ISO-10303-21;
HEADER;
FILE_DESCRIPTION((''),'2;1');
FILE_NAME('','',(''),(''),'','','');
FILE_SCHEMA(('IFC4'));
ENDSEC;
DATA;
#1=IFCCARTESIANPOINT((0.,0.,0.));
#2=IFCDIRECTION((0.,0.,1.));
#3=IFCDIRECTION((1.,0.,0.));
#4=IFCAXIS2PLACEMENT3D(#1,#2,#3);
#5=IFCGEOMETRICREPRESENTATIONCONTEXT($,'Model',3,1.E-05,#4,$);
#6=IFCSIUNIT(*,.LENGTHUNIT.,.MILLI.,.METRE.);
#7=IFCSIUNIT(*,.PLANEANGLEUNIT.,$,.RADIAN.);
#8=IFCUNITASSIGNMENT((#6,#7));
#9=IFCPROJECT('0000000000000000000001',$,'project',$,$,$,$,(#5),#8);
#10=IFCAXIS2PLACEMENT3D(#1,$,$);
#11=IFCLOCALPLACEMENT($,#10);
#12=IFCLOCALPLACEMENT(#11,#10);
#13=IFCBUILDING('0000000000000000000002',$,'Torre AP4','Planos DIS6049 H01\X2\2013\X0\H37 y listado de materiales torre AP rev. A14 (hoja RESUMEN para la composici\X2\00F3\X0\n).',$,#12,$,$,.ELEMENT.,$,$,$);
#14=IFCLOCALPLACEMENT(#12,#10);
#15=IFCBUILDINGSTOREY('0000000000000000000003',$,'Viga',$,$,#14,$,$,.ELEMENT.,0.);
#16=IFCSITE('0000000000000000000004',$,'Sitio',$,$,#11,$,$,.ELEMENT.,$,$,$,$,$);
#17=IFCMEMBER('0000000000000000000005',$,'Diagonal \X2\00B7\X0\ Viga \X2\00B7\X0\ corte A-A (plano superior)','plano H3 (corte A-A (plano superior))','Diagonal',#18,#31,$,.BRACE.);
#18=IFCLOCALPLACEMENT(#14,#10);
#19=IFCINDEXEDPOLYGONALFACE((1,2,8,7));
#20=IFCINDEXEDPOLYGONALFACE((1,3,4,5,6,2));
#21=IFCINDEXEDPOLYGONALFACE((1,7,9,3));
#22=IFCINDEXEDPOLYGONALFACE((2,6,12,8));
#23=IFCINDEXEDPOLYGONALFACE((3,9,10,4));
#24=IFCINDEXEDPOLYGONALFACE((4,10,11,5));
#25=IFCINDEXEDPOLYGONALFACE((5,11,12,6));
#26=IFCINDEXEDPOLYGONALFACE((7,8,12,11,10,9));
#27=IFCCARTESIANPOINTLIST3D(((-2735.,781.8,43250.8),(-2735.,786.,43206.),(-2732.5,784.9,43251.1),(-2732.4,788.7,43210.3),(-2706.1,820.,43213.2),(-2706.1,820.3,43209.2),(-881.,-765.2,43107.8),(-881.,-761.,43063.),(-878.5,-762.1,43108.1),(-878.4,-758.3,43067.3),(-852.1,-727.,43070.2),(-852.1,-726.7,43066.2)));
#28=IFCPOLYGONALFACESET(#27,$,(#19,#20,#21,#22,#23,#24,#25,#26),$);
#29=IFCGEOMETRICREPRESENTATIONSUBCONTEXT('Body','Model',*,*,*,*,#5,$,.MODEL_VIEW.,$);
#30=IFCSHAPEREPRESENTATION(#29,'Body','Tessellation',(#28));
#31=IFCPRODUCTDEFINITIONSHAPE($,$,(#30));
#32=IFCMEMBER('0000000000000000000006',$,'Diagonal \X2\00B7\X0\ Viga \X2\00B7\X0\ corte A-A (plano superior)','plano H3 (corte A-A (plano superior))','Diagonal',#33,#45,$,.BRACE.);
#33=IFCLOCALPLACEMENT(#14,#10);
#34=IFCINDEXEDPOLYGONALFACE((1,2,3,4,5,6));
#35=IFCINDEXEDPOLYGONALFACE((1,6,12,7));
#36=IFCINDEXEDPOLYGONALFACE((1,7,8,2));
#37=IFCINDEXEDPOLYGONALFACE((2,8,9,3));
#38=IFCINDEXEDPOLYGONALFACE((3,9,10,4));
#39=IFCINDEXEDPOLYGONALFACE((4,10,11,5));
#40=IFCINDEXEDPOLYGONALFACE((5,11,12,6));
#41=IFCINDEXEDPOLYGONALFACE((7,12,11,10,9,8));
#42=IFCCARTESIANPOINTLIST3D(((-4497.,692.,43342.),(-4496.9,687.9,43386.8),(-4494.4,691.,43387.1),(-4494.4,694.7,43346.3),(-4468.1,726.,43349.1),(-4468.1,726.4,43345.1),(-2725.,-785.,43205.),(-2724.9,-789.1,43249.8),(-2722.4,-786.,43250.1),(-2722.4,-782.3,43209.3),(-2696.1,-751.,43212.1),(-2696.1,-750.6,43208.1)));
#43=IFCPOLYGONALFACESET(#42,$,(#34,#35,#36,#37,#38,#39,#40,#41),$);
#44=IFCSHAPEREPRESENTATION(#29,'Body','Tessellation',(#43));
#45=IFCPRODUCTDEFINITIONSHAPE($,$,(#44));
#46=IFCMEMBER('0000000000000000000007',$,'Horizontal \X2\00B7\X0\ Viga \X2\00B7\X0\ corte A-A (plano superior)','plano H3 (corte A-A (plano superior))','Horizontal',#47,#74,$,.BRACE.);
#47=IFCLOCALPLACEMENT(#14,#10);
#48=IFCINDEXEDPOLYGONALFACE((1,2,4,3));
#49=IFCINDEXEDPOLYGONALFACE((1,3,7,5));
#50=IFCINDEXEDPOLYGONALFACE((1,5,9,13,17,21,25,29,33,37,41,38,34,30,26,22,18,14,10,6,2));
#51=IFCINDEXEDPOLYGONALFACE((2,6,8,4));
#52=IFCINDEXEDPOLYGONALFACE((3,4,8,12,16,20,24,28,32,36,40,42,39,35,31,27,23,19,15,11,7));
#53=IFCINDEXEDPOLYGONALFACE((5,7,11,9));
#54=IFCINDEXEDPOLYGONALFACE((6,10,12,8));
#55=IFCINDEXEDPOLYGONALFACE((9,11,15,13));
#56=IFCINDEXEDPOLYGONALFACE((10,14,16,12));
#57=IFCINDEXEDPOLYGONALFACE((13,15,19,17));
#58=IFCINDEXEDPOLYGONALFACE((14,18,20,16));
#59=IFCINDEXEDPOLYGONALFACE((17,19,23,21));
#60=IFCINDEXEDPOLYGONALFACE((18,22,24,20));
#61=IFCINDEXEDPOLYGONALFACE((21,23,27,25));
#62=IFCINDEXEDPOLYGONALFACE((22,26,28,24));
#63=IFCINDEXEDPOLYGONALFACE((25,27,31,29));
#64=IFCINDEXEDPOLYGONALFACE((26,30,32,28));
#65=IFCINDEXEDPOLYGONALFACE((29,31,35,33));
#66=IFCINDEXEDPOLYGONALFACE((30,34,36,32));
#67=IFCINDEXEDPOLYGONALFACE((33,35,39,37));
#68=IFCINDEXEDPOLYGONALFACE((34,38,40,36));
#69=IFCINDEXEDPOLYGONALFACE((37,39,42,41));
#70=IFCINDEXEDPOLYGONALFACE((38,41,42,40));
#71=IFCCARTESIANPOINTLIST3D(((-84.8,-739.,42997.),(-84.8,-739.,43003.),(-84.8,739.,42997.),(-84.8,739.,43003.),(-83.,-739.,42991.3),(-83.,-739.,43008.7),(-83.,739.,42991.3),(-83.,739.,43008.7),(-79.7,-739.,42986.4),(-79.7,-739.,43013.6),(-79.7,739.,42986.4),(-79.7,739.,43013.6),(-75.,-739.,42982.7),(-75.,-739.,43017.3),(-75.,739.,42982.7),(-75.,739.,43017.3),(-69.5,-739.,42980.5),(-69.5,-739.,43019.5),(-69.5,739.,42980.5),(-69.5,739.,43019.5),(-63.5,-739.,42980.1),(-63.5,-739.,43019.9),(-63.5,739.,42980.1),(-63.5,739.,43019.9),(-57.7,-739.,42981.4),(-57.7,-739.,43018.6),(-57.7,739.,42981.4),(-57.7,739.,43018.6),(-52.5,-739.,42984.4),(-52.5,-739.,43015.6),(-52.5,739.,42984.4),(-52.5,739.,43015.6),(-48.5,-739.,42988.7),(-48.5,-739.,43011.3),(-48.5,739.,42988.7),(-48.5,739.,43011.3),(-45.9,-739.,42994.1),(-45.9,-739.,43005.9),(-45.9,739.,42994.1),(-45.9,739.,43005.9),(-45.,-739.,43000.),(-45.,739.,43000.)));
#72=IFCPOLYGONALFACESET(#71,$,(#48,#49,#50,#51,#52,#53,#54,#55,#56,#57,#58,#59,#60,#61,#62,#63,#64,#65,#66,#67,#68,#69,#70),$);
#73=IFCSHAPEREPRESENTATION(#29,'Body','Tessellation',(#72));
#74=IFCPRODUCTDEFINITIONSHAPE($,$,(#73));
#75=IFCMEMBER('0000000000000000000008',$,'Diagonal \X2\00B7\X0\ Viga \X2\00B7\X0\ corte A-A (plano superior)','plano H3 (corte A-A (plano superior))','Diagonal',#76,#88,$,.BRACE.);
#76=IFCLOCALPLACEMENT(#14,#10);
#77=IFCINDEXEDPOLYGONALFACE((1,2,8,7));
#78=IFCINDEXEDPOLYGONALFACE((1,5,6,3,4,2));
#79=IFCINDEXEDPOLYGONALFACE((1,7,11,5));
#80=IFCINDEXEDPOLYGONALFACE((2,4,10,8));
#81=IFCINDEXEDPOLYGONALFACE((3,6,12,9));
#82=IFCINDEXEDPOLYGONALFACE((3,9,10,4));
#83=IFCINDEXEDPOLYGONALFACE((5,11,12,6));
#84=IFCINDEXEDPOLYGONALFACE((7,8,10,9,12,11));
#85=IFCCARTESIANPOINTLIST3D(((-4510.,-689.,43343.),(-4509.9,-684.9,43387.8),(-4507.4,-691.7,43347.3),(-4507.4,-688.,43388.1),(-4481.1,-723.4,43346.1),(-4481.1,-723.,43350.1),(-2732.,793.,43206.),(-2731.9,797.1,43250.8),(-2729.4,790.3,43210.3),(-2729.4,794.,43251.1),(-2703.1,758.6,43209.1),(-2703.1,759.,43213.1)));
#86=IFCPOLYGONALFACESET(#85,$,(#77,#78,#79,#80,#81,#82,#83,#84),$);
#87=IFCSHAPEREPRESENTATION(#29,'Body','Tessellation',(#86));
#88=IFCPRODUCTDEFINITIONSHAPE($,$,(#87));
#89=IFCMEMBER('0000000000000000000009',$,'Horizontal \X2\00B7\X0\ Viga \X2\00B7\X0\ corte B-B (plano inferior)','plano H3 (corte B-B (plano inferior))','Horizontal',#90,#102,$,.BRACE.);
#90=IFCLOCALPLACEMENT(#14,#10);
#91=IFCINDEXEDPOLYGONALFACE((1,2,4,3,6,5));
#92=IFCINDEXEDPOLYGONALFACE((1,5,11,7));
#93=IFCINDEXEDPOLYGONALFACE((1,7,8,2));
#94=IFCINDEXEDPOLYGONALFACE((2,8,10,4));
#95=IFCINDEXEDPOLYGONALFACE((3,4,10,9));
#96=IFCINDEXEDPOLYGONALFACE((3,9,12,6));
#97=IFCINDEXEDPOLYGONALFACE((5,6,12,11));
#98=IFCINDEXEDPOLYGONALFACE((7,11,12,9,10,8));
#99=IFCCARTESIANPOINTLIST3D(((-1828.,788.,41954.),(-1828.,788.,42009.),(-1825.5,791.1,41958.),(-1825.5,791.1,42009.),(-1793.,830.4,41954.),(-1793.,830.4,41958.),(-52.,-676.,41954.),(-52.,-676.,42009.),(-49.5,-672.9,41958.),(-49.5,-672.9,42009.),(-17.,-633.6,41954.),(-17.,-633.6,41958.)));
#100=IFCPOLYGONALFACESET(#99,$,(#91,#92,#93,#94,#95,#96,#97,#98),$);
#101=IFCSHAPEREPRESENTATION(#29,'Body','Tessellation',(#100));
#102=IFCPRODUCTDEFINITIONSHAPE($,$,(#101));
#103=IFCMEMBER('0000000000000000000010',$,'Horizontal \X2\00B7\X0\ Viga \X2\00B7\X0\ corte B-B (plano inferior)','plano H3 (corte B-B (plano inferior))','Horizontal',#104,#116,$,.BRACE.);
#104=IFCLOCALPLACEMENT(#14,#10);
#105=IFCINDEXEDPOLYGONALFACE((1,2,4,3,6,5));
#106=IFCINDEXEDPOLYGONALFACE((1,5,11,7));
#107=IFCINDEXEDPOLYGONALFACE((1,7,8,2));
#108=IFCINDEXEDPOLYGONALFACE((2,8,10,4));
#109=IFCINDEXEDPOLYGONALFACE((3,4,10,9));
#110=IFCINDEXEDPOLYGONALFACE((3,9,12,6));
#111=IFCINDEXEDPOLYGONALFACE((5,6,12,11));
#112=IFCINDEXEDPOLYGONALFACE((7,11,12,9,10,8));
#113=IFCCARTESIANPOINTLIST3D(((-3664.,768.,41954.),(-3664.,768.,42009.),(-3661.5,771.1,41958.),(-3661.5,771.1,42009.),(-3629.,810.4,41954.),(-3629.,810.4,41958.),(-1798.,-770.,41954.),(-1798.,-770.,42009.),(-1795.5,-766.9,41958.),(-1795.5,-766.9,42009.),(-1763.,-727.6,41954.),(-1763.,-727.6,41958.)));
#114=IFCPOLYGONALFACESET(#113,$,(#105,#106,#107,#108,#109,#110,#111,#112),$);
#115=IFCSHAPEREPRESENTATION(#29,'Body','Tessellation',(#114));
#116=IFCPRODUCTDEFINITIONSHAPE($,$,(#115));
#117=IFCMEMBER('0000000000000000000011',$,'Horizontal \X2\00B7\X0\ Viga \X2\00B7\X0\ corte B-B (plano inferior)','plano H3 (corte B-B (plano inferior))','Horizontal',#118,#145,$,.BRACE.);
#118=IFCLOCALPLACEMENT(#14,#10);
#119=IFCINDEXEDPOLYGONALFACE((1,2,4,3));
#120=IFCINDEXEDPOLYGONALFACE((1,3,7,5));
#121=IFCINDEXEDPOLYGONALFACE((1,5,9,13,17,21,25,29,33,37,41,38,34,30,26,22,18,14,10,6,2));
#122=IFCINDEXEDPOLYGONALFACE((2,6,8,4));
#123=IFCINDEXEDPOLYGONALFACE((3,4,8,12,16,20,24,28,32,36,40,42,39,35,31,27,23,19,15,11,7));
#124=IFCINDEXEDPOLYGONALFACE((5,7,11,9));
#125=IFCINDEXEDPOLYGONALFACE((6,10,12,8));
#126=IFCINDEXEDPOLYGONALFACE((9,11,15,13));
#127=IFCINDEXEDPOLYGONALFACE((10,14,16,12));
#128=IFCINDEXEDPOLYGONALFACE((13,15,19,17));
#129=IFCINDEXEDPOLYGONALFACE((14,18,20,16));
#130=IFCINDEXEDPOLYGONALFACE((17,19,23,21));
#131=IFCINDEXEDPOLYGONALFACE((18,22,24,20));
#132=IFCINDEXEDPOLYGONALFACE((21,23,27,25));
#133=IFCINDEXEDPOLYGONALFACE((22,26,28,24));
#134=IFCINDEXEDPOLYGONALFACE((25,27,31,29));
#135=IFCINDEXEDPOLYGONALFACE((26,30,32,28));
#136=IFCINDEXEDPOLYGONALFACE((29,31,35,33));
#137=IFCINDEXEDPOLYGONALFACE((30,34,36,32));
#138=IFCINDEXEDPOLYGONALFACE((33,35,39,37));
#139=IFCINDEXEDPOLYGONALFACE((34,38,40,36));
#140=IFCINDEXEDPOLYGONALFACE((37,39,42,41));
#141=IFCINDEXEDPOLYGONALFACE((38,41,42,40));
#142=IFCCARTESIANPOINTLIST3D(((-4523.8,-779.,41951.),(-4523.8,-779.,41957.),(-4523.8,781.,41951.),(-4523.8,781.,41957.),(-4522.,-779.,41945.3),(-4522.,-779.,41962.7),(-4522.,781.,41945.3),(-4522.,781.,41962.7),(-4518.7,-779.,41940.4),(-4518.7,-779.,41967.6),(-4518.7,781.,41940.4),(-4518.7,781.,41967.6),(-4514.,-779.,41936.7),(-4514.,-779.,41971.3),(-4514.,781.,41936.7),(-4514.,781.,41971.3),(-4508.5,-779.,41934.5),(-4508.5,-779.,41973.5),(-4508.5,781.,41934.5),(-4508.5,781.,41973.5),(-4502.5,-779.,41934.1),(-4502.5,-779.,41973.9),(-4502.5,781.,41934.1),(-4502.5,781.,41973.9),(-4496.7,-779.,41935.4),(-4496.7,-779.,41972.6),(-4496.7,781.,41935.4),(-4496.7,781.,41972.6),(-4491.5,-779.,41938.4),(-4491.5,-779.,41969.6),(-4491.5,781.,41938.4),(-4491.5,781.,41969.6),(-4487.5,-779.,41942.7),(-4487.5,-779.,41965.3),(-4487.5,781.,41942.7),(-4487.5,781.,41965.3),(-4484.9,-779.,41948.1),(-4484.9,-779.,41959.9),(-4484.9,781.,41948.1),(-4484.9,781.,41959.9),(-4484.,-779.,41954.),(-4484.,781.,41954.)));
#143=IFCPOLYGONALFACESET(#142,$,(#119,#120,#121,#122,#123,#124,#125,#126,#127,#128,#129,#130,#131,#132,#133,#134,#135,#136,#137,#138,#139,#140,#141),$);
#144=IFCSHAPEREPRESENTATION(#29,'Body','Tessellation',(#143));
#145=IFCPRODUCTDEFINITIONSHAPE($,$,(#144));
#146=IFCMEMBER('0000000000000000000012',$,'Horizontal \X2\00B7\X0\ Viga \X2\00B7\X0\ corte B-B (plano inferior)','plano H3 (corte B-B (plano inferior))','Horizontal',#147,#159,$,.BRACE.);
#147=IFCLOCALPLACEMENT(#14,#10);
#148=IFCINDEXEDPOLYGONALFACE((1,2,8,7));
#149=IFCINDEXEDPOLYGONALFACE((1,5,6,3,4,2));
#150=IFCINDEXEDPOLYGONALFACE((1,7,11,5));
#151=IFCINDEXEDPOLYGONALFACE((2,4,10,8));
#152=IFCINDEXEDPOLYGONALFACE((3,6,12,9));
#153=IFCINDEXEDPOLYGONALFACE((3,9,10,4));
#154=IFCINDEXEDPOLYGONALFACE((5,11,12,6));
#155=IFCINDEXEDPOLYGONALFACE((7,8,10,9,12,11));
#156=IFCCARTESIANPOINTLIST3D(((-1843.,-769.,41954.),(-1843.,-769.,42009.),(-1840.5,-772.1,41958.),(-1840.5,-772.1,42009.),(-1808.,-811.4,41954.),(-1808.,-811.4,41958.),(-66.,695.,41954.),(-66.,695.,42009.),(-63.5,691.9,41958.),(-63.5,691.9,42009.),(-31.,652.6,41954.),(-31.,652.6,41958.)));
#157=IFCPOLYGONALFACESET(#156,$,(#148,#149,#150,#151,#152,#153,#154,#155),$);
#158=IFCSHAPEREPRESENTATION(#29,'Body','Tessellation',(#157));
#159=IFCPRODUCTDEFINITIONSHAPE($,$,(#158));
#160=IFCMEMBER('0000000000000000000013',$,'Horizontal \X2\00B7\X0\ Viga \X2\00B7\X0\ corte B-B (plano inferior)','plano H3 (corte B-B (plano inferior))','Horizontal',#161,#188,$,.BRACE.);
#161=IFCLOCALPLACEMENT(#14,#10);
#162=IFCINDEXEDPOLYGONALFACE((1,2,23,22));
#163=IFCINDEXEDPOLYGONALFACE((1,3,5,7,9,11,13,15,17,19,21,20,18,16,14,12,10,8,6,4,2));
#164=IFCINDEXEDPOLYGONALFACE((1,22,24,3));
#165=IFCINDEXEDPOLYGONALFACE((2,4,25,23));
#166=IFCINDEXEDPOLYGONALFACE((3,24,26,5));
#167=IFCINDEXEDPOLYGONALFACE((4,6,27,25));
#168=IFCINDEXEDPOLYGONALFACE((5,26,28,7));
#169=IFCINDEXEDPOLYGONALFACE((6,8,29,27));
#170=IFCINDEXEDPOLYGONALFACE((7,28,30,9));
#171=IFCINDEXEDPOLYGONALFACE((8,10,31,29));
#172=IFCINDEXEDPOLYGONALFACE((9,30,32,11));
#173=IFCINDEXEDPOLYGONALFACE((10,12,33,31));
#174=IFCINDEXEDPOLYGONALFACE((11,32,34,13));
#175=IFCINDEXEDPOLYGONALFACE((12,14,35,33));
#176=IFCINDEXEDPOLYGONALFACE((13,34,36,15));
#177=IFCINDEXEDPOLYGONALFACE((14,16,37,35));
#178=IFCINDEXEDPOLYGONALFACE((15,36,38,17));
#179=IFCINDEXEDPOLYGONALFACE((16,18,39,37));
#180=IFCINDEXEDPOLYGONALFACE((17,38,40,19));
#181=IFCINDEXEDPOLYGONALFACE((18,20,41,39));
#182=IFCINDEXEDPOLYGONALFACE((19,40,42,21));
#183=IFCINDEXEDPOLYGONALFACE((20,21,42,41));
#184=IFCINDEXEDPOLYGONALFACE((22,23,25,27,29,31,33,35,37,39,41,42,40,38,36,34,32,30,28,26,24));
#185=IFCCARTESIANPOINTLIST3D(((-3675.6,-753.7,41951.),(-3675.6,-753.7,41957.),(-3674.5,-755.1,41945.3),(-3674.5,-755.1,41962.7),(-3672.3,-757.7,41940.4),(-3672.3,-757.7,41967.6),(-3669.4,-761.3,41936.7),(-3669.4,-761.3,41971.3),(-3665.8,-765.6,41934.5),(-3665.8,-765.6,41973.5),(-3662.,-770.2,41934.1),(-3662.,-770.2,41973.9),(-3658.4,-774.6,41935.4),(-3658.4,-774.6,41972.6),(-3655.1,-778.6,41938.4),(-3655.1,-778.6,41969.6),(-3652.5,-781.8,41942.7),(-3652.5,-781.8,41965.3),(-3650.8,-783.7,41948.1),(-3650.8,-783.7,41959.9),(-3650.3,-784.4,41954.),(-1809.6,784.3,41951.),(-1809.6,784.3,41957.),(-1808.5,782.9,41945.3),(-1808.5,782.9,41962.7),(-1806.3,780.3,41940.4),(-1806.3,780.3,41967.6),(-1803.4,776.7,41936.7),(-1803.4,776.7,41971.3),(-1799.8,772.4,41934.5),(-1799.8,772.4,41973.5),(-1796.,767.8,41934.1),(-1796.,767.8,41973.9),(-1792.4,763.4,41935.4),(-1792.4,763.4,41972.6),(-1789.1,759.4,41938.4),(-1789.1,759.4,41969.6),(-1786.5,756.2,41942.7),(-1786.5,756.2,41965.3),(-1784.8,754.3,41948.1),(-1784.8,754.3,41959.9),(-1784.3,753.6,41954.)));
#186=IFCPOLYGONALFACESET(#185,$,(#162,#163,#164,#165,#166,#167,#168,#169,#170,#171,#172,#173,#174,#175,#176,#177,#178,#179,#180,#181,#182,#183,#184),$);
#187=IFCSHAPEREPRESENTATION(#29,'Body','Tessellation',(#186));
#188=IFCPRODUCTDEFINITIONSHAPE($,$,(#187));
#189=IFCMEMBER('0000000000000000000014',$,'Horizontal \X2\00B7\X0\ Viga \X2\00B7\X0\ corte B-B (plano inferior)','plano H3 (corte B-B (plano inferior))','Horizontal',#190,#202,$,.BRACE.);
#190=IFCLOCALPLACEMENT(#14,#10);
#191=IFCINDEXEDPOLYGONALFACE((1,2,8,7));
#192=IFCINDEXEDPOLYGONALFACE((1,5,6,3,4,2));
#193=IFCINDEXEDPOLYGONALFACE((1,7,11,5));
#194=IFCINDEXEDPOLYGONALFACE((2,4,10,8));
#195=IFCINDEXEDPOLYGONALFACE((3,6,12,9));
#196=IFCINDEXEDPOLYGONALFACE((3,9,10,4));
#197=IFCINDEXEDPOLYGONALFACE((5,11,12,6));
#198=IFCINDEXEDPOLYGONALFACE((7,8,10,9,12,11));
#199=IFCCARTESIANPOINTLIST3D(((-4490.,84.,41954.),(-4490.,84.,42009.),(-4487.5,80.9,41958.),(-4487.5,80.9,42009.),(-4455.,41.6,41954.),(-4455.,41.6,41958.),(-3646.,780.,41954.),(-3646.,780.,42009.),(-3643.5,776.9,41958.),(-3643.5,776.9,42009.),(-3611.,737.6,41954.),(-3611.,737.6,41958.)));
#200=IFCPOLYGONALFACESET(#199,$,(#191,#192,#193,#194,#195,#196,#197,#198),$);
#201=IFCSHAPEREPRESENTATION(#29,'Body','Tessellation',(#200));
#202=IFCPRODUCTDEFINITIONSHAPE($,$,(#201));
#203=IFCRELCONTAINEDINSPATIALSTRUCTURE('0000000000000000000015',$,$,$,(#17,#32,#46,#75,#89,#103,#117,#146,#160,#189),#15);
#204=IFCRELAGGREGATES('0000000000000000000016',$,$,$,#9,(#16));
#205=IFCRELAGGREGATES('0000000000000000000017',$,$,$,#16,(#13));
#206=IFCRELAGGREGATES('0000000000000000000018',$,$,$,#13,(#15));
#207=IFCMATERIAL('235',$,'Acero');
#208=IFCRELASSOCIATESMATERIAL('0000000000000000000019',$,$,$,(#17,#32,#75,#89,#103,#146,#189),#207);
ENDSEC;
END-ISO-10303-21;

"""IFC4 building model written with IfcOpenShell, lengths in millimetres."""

from ifc_helpers import new_model, si_unit, frame, frame_2d, origin, origin_with_axes, place, context, subcontext, project, spatial, circle, l_section, extrude, material, element, save


model = new_model("IFC4")

# Units and contexts
model_context = context("Model", 3, precision=1e-05, world=origin_with_axes())
body_context = subcontext(model_context, "Body", "Model", "MODEL_VIEW")
ifc_project = project(units=[si_unit("LENGTHUNIT", "METRE", prefix="MILLI"), si_unit("PLANEANGLEUNIT", "RADIAN")], contexts=[model_context])

# Site, building, storey
site_placement = place(None, origin())
site = spatial("IfcSite", under=ifc_project, at=site_placement, Name="Sitio", CompositionType="ELEMENT")
building_placement = place(site_placement, origin())
building = spatial("IfcBuilding", under=site, at=building_placement, Name="Torre AP4", Description="Planos DIS6049 H01–H37 y listado de materiales torre AP rev. A14 (hoja RESUMEN para la composición).", CompositionType="ELEMENT")
storey_placement = place(building_placement, origin())
storey = spatial("IfcBuildingStorey", under=building, at=storey_placement, Name="Viga", CompositionType="ELEMENT", Elevation=0.0)

# Members
ifc_material = material(Name="235", Category="Acero")
member_1_placement = place(storey_placement, frame((-2735.0, 786.0, 43206.0), z_axis=(0.766471, -0.639553, -0.059118), x_axis=(0.642279, 0.763125, 0.071544)))
element("IfcMember", 1, at=member_1_placement, inside=storey, material=ifc_material, Name="Diagonal · Viga · corte A-A (plano superior)", Description="plano H3 (corte A-A (plano superior))", ObjectType="Diagonal", PredefinedType="BRACE", context=body_context, shape_type="SweptSolid", body=[
    extrude(l_section(Depth=45.0, Width=45.0, Thickness=4.0, at=frame_2d((22.5, 22.5))), None, (0.0, 0.0, 1.0), 2418.9),
])
member_2_placement = place(storey_placement, frame((-4497.0, 692.0, 43342.0), z_axis=(0.766799, -0.639144, -0.059284), x_axis=(0.641886, 0.763689, 0.069004)))
element("IfcMember", 2, at=member_2_placement, inside=storey, material=ifc_material, Name="Diagonal · Viga · corte A-A (plano superior)", Description="plano H3 (corte A-A (plano superior))", ObjectType="Diagonal", PredefinedType="BRACE", context=body_context, shape_type="SweptSolid", body=[
    extrude(l_section(Depth=45.0, Width=45.0, Thickness=4.0, at=frame_2d((22.5, 22.5))), None, (0.0, 0.0, 1.0), 2310.9),
])
member_3_placement = place(storey_placement, frame((-65.0, 739.0, 43000.0), z_axis=(0.0, -1.0, 0.0), x_axis=(1.0, 0.0, 0.0)))
element("IfcMember", 3, at=member_3_placement, inside=storey, Name="Horizontal · Viga · corte A-A (plano superior)", Description="plano H3 (corte A-A (plano superior))", ObjectType="Horizontal", PredefinedType="BRACE", context=body_context, shape_type="SweptSolid", body=[
    extrude(circle(Radius=20.0), None, (0.0, 0.0, 1.0), 1478.0),
])
member_4_placement = place(storey_placement, frame((-2732.0, 793.0, 43206.0), z_axis=(-0.766808, -0.639151, 0.059085), x_axis=(0.641875, -0.763738, 0.068568)))
element("IfcMember", 4, at=member_4_placement, inside=storey, material=ifc_material, Name="Diagonal · Viga · corte A-A (plano superior)", Description="plano H3 (corte A-A (plano superior))", ObjectType="Diagonal", PredefinedType="BRACE", context=body_context, shape_type="SweptSolid", body=[
    extrude(l_section(Depth=45.0, Width=45.0, Thickness=4.0, at=frame_2d((22.5, 22.5))), None, (0.0, 0.0, 1.0), 2318.7),
])
member_5_placement = place(storey_placement, frame((-1828.0, 788.0, 41954.0), z_axis=(0.771629, -0.636073, 0.0), x_axis=(0.636073, 0.771629, 0.0)))
element("IfcMember", 5, at=member_5_placement, inside=storey, material=ifc_material, Name="Horizontal · Viga · corte B-B (plano inferior)", Description="plano H3 (corte B-B (plano inferior))", ObjectType="Horizontal", PredefinedType="BRACE", context=body_context, shape_type="SweptSolid", body=[
    extrude(l_section(Depth=55.0, Width=55.0, Thickness=4.0, at=frame_2d((27.5, 27.5))), None, (0.0, 0.0, 1.0), 2301.6),
])
member_6_placement = place(storey_placement, frame((-3664.0, 768.0, 41954.0), z_axis=(0.771668, -0.636026, 0.0), x_axis=(0.636026, 0.771668, 0.0)))
element("IfcMember", 6, at=member_6_placement, inside=storey, material=ifc_material, Name="Horizontal · Viga · corte B-B (plano inferior)", Description="plano H3 (corte B-B (plano inferior))", ObjectType="Horizontal", PredefinedType="BRACE", context=body_context, shape_type="SweptSolid", body=[
    extrude(l_section(Depth=55.0, Width=55.0, Thickness=4.0, at=frame_2d((27.5, 27.5))), None, (0.0, 0.0, 1.0), 2418.1),
])
member_7_placement = place(storey_placement, frame((-4504.0, 781.0, 41954.0), z_axis=(0.0, -1.0, 0.0), x_axis=(1.0, 0.0, 0.0)))
element("IfcMember", 7, at=member_7_placement, inside=storey, Name="Horizontal · Viga · corte B-B (plano inferior)", Description="plano H3 (corte B-B (plano inferior))", ObjectType="Horizontal", PredefinedType="BRACE", context=body_context, shape_type="SweptSolid", body=[
    extrude(circle(Radius=20.0), None, (0.0, 0.0, 1.0), 1560.0),
])
member_8_placement = place(storey_placement, frame((-66.0, 695.0, 41954.0), z_axis=(-0.771805, -0.635859, 0.0), x_axis=(0.635859, -0.771805, 0.0)))
element("IfcMember", 8, at=member_8_placement, inside=storey, material=ifc_material, Name="Horizontal · Viga · corte B-B (plano inferior)", Description="plano H3 (corte B-B (plano inferior))", ObjectType="Horizontal", PredefinedType="BRACE", context=body_context, shape_type="SweptSolid", body=[
    extrude(l_section(Depth=55.0, Width=55.0, Thickness=4.0, at=frame_2d((27.5, 27.5))), None, (0.0, 0.0, 1.0), 2302.4),
])
member_9_placement = place(storey_placement, frame((-1797.0, 769.0, 41954.0), z_axis=(-0.771668, -0.636026, 0.0), x_axis=(0.636026, -0.771668, 0.0)))
element("IfcMember", 9, at=member_9_placement, inside=storey, Name="Horizontal · Viga · corte B-B (plano inferior)", Description="plano H3 (corte B-B (plano inferior))", ObjectType="Horizontal", PredefinedType="BRACE", context=body_context, shape_type="SweptSolid", body=[
    extrude(circle(Radius=20.0), None, (0.0, 0.0, 1.0), 2418.1),
])
member_10_placement = place(storey_placement, frame((-3646.0, 780.0, 41954.0), z_axis=(-0.771508, -0.63622, 0.0), x_axis=(0.63622, -0.771508, 0.0)))
element("IfcMember", 10, at=member_10_placement, inside=storey, material=ifc_material, Name="Horizontal · Viga · corte B-B (plano inferior)", Description="plano H3 (corte B-B (plano inferior))", ObjectType="Horizontal", PredefinedType="BRACE", context=body_context, shape_type="SweptSolid", body=[
    extrude(l_section(Depth=55.0, Width=55.0, Thickness=4.0, at=frame_2d((27.5, 27.5))), None, (0.0, 0.0, 1.0), 1094.0),
])

save(model, "model.ifc")
